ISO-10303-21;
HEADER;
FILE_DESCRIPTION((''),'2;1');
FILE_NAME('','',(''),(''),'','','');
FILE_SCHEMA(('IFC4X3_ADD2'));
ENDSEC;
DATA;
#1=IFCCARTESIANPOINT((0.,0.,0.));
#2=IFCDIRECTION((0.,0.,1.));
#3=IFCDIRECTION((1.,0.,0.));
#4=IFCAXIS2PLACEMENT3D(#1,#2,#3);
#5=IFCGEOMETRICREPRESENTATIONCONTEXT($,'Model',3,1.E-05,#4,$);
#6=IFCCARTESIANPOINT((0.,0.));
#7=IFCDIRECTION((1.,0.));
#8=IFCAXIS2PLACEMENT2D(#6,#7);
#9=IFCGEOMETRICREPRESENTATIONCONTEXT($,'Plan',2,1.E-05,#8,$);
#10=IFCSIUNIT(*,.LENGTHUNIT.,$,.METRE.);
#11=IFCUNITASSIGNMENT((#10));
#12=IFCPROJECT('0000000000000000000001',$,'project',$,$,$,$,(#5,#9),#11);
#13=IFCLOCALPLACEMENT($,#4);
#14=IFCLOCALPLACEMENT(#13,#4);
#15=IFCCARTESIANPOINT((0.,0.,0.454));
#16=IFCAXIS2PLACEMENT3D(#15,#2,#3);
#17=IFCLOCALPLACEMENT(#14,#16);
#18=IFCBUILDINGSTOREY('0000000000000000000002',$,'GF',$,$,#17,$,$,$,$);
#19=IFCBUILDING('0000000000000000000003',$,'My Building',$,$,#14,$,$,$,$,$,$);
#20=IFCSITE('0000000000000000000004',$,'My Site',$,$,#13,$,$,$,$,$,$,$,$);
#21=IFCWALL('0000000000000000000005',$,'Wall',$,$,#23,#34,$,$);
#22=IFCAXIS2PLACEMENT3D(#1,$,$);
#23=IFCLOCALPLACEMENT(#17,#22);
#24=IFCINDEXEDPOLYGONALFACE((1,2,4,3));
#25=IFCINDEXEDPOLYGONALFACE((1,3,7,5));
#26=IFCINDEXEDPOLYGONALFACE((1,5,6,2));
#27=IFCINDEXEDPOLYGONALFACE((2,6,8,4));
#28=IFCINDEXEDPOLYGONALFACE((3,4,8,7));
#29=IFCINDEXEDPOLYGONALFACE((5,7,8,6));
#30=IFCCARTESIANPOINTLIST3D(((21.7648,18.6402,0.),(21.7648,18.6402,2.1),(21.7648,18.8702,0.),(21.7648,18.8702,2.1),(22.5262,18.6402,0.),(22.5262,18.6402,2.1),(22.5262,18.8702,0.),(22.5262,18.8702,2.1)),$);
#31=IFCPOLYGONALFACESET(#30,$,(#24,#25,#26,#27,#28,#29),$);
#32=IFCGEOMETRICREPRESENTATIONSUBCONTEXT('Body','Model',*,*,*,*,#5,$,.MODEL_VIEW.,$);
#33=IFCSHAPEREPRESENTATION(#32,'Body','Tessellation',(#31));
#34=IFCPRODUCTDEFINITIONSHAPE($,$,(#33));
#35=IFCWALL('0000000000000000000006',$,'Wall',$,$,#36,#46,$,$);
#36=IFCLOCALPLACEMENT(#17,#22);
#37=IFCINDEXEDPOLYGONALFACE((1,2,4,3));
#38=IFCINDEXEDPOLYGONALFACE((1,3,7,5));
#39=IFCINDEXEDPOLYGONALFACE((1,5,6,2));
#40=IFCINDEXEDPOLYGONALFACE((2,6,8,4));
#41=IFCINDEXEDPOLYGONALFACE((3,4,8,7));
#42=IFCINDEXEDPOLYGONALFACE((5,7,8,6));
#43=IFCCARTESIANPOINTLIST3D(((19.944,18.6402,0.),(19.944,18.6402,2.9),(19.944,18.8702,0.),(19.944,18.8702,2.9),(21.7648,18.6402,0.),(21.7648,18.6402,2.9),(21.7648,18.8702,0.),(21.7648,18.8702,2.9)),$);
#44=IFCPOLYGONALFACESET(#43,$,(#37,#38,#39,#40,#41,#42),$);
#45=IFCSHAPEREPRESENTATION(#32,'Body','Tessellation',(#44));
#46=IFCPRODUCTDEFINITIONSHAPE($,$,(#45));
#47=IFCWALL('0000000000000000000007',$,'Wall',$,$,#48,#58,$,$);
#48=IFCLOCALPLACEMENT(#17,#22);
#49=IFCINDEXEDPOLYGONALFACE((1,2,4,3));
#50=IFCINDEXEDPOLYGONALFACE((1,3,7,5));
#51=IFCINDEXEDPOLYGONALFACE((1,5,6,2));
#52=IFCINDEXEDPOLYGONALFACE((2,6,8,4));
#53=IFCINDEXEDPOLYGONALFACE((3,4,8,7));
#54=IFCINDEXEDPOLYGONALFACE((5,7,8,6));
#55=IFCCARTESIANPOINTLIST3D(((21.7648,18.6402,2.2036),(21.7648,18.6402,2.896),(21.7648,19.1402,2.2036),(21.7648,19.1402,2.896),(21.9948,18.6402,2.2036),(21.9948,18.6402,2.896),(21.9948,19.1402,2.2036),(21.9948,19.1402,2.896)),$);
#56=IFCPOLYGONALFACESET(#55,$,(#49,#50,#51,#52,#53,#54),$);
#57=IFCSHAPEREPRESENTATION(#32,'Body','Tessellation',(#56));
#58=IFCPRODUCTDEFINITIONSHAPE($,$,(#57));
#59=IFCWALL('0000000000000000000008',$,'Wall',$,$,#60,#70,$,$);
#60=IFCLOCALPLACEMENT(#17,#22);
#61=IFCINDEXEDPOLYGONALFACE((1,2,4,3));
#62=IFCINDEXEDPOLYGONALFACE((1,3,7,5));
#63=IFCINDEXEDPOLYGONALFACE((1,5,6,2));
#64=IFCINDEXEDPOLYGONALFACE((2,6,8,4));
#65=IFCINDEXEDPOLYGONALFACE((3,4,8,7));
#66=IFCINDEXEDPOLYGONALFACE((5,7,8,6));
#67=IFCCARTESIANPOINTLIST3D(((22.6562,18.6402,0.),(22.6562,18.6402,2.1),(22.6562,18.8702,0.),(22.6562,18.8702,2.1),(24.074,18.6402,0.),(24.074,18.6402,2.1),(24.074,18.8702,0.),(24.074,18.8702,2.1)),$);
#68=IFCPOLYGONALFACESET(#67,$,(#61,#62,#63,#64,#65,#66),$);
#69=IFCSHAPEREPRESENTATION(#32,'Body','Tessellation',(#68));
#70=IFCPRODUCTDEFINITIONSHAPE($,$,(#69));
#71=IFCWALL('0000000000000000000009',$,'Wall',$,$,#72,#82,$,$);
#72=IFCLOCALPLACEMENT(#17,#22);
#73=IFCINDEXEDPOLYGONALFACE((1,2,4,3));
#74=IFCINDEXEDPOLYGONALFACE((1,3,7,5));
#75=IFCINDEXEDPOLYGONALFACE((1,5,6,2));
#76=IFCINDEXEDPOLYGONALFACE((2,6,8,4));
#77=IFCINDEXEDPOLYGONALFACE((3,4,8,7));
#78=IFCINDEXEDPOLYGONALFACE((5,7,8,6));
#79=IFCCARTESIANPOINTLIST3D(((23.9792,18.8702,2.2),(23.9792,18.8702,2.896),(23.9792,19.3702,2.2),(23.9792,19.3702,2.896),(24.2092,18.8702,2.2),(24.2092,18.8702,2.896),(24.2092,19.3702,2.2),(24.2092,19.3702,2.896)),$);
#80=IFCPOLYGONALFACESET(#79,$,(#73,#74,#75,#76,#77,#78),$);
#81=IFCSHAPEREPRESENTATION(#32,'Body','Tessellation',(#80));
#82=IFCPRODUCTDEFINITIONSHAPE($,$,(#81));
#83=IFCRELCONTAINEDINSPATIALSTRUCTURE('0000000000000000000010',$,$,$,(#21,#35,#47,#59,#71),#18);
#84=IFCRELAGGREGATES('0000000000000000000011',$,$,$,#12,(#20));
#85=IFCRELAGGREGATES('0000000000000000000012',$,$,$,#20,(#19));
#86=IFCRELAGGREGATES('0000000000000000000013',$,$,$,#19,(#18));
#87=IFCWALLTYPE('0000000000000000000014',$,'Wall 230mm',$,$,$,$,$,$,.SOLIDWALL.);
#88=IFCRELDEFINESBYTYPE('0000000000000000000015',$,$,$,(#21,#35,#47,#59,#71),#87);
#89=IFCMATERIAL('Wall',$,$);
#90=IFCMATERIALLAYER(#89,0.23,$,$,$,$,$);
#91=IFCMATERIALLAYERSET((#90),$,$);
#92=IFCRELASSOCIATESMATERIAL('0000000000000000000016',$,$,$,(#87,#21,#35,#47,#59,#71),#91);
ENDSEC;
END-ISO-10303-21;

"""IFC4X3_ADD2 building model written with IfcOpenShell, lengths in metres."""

from ifc_helpers import new_model, si_unit, frame, origin_with_axes, origin_2d_with_axis, place, context, subcontext, project, spatial, indexed_curve, outline, extrude, clip, halfspace, material, layer, layer_set, layer_usage, type_object, element, save


model = new_model("IFC4X3_ADD2")

# Units and contexts
model_context = context("Model", 3, precision=1e-05, world=origin_with_axes())
plan_context = context("Plan", 2, precision=1e-05, world=origin_2d_with_axis())
body_context_1 = subcontext(model_context, "Body", "Model", "MODEL_VIEW")
ifc_project = project(units=[si_unit("LENGTHUNIT", "METRE")], contexts=[model_context, plan_context])

# Site, building, storey
site_placement = place(None, origin_with_axes())
site = spatial("IfcSite", under=ifc_project, at=site_placement, Name="My Site")
building_placement = place(site_placement, origin_with_axes())
building = spatial("IfcBuilding", under=site, at=building_placement, Name="My Building")
storey_placement = place(building_placement, frame((0.0, 0.0, 0.454), z_axis=(0.0, 0.0, 1.0), x_axis=(1.0, 0.0, 0.0)))
storey = spatial("IfcBuildingStorey", under=building, at=storey_placement, Name="GF")

# Shared definitions
ifc_material_1 = material(Name="Wall")

# Shared definitions
ifc_layer_1 = layer(ifc_material_1, 0.23)
ifc_layer_set_1 = layer_set([ifc_layer_1])
wall_type_1 = type_object("IfcWallType", Name="Wall 230mm", PredefinedType="SOLIDWALL", material=ifc_layer_set_1)

# Walls
ifc_layer_usage_1 = layer_usage(ifc_layer_set_1, "AXIS2", "POSITIVE", 0.0)
wall_1_placement = place(storey_placement, frame((21.7648, 18.6402, 0.0), z_axis=(0.0, 0.0, 1.0), x_axis=(1.0, -0.000001, 0.0)))
element("IfcWall", 1, at=wall_1_placement, inside=storey, type_object=wall_type_1, material=ifc_layer_usage_1, Name="Wall", context=body_context_1, shape_type="Clipping", body=[
    clip(extrude(outline(indexed_curve([(0.0, 0.0), (0.0, 0.23), (0.7614, 0.23), (0.7614, 0.0), (0.0, 0.0)], self_intersect=False)), origin_with_axes(), (0.0, 0.0, 1.0), 2.554), halfspace(frame((0.0, 0.0, 2.1), z_axis=(0.0, 0.0, 1.0), x_axis=(-1.0, 0.0, 0.0)), False)),
])
ifc_layer_usage_2 = layer_usage(ifc_layer_set_1, "AXIS2", "POSITIVE", 0.0)
wall_2_placement = place(storey_placement, frame((19.944, 18.6402, 0.0), z_axis=(0.0, 0.0, 1.0), x_axis=(1.0, -0.000001, 0.0)))
element("IfcWall", 2, at=wall_2_placement, inside=storey, type_object=wall_type_1, material=ifc_layer_usage_2, Name="Wall", context=body_context_1, shape_type="SweptSolid", body=[
    extrude(outline(indexed_curve([(0.0, 0.0), (0.0, 0.23), (1.8208, 0.23), (1.8208, 0.0), (0.0, 0.0)], self_intersect=False)), origin_with_axes(), (0.0, 0.0, 1.0), 2.9),
])
ifc_layer_usage_3 = layer_usage(ifc_layer_set_1, "AXIS2", "POSITIVE", 0.0)
wall_3_placement = place(storey_placement, frame((21.9948, 18.6402, 2.2036), z_axis=(0.0, 0.0, 1.0), x_axis=(0.000001, 1.0, 0.0)))
element("IfcWall", 3, at=wall_3_placement, inside=storey, type_object=wall_type_1, material=ifc_layer_usage_3, Name="Wall", context=body_context_1, shape_type="Clipping", body=[
    clip(extrude(outline(indexed_curve([(0.0, 0.0), (0.0, 0.23), (0.5, 0.23), (0.5, 0.0), (0.0, 0.0)], self_intersect=False)), origin_with_axes(), (0.0, 0.0, 1.0), 3.35), halfspace(frame((0.0, 0.0, 0.6924), z_axis=(0.0, 0.0, 1.0), x_axis=(-1.0, 0.0, 0.0)), False)),
])
ifc_layer_usage_4 = layer_usage(ifc_layer_set_1, "AXIS2", "POSITIVE", 0.0)
wall_4_placement = place(storey_placement, frame((24.074, 18.8702, 0.0), z_axis=(0.0, 0.0, 1.0), x_axis=(-1.0, 0.0, 0.0)))
element("IfcWall", 4, at=wall_4_placement, inside=storey, type_object=wall_type_1, material=ifc_layer_usage_4, Name="Wall", context=body_context_1, shape_type="Clipping", body=[
    clip(extrude(outline(indexed_curve([(0.0, 0.0), (0.0, 0.23), (1.4178, 0.23), (1.4178, 0.0), (0.0, 0.0)], self_intersect=False)), origin_with_axes(), (0.0, 0.0, 1.0), 2.554), halfspace(frame((0.0, 0.0, 2.1), z_axis=(0.0, 0.0, 1.0), x_axis=(-1.0, 0.0, 0.0)), False)),
])
ifc_layer_usage_5 = layer_usage(ifc_layer_set_1, "AXIS2", "POSITIVE", 0.0)
wall_5_placement = place(storey_placement, frame((23.9792, 19.3702, 2.2), z_axis=(0.0, 0.0, 1.0), x_axis=(0.0, -1.0, 0.0)))
element("IfcWall", 5, at=wall_5_placement, inside=storey, type_object=wall_type_1, material=ifc_layer_usage_5, Name="Wall", context=body_context_1, shape_type="Clipping", body=[
    clip(clip(extrude(outline(indexed_curve([(0.0, 0.0), (0.0, 0.23), (0.5, 0.23), (0.5, 0.0), (0.0, 0.0)], self_intersect=False)), origin_with_axes(), (0.0, 0.0, 1.0), 6.25), halfspace(frame((0.0, 0.0, 3.596), z_axis=(0.0, 0.0, 1.0), x_axis=(-1.0, 0.0, 0.0)), False)), halfspace(frame((0.0, 0.0, 0.696), z_axis=(0.0, 0.0, 1.0), x_axis=(-1.0, 0.0, 0.0)), False)),
])

save(model, "model.ifc")
